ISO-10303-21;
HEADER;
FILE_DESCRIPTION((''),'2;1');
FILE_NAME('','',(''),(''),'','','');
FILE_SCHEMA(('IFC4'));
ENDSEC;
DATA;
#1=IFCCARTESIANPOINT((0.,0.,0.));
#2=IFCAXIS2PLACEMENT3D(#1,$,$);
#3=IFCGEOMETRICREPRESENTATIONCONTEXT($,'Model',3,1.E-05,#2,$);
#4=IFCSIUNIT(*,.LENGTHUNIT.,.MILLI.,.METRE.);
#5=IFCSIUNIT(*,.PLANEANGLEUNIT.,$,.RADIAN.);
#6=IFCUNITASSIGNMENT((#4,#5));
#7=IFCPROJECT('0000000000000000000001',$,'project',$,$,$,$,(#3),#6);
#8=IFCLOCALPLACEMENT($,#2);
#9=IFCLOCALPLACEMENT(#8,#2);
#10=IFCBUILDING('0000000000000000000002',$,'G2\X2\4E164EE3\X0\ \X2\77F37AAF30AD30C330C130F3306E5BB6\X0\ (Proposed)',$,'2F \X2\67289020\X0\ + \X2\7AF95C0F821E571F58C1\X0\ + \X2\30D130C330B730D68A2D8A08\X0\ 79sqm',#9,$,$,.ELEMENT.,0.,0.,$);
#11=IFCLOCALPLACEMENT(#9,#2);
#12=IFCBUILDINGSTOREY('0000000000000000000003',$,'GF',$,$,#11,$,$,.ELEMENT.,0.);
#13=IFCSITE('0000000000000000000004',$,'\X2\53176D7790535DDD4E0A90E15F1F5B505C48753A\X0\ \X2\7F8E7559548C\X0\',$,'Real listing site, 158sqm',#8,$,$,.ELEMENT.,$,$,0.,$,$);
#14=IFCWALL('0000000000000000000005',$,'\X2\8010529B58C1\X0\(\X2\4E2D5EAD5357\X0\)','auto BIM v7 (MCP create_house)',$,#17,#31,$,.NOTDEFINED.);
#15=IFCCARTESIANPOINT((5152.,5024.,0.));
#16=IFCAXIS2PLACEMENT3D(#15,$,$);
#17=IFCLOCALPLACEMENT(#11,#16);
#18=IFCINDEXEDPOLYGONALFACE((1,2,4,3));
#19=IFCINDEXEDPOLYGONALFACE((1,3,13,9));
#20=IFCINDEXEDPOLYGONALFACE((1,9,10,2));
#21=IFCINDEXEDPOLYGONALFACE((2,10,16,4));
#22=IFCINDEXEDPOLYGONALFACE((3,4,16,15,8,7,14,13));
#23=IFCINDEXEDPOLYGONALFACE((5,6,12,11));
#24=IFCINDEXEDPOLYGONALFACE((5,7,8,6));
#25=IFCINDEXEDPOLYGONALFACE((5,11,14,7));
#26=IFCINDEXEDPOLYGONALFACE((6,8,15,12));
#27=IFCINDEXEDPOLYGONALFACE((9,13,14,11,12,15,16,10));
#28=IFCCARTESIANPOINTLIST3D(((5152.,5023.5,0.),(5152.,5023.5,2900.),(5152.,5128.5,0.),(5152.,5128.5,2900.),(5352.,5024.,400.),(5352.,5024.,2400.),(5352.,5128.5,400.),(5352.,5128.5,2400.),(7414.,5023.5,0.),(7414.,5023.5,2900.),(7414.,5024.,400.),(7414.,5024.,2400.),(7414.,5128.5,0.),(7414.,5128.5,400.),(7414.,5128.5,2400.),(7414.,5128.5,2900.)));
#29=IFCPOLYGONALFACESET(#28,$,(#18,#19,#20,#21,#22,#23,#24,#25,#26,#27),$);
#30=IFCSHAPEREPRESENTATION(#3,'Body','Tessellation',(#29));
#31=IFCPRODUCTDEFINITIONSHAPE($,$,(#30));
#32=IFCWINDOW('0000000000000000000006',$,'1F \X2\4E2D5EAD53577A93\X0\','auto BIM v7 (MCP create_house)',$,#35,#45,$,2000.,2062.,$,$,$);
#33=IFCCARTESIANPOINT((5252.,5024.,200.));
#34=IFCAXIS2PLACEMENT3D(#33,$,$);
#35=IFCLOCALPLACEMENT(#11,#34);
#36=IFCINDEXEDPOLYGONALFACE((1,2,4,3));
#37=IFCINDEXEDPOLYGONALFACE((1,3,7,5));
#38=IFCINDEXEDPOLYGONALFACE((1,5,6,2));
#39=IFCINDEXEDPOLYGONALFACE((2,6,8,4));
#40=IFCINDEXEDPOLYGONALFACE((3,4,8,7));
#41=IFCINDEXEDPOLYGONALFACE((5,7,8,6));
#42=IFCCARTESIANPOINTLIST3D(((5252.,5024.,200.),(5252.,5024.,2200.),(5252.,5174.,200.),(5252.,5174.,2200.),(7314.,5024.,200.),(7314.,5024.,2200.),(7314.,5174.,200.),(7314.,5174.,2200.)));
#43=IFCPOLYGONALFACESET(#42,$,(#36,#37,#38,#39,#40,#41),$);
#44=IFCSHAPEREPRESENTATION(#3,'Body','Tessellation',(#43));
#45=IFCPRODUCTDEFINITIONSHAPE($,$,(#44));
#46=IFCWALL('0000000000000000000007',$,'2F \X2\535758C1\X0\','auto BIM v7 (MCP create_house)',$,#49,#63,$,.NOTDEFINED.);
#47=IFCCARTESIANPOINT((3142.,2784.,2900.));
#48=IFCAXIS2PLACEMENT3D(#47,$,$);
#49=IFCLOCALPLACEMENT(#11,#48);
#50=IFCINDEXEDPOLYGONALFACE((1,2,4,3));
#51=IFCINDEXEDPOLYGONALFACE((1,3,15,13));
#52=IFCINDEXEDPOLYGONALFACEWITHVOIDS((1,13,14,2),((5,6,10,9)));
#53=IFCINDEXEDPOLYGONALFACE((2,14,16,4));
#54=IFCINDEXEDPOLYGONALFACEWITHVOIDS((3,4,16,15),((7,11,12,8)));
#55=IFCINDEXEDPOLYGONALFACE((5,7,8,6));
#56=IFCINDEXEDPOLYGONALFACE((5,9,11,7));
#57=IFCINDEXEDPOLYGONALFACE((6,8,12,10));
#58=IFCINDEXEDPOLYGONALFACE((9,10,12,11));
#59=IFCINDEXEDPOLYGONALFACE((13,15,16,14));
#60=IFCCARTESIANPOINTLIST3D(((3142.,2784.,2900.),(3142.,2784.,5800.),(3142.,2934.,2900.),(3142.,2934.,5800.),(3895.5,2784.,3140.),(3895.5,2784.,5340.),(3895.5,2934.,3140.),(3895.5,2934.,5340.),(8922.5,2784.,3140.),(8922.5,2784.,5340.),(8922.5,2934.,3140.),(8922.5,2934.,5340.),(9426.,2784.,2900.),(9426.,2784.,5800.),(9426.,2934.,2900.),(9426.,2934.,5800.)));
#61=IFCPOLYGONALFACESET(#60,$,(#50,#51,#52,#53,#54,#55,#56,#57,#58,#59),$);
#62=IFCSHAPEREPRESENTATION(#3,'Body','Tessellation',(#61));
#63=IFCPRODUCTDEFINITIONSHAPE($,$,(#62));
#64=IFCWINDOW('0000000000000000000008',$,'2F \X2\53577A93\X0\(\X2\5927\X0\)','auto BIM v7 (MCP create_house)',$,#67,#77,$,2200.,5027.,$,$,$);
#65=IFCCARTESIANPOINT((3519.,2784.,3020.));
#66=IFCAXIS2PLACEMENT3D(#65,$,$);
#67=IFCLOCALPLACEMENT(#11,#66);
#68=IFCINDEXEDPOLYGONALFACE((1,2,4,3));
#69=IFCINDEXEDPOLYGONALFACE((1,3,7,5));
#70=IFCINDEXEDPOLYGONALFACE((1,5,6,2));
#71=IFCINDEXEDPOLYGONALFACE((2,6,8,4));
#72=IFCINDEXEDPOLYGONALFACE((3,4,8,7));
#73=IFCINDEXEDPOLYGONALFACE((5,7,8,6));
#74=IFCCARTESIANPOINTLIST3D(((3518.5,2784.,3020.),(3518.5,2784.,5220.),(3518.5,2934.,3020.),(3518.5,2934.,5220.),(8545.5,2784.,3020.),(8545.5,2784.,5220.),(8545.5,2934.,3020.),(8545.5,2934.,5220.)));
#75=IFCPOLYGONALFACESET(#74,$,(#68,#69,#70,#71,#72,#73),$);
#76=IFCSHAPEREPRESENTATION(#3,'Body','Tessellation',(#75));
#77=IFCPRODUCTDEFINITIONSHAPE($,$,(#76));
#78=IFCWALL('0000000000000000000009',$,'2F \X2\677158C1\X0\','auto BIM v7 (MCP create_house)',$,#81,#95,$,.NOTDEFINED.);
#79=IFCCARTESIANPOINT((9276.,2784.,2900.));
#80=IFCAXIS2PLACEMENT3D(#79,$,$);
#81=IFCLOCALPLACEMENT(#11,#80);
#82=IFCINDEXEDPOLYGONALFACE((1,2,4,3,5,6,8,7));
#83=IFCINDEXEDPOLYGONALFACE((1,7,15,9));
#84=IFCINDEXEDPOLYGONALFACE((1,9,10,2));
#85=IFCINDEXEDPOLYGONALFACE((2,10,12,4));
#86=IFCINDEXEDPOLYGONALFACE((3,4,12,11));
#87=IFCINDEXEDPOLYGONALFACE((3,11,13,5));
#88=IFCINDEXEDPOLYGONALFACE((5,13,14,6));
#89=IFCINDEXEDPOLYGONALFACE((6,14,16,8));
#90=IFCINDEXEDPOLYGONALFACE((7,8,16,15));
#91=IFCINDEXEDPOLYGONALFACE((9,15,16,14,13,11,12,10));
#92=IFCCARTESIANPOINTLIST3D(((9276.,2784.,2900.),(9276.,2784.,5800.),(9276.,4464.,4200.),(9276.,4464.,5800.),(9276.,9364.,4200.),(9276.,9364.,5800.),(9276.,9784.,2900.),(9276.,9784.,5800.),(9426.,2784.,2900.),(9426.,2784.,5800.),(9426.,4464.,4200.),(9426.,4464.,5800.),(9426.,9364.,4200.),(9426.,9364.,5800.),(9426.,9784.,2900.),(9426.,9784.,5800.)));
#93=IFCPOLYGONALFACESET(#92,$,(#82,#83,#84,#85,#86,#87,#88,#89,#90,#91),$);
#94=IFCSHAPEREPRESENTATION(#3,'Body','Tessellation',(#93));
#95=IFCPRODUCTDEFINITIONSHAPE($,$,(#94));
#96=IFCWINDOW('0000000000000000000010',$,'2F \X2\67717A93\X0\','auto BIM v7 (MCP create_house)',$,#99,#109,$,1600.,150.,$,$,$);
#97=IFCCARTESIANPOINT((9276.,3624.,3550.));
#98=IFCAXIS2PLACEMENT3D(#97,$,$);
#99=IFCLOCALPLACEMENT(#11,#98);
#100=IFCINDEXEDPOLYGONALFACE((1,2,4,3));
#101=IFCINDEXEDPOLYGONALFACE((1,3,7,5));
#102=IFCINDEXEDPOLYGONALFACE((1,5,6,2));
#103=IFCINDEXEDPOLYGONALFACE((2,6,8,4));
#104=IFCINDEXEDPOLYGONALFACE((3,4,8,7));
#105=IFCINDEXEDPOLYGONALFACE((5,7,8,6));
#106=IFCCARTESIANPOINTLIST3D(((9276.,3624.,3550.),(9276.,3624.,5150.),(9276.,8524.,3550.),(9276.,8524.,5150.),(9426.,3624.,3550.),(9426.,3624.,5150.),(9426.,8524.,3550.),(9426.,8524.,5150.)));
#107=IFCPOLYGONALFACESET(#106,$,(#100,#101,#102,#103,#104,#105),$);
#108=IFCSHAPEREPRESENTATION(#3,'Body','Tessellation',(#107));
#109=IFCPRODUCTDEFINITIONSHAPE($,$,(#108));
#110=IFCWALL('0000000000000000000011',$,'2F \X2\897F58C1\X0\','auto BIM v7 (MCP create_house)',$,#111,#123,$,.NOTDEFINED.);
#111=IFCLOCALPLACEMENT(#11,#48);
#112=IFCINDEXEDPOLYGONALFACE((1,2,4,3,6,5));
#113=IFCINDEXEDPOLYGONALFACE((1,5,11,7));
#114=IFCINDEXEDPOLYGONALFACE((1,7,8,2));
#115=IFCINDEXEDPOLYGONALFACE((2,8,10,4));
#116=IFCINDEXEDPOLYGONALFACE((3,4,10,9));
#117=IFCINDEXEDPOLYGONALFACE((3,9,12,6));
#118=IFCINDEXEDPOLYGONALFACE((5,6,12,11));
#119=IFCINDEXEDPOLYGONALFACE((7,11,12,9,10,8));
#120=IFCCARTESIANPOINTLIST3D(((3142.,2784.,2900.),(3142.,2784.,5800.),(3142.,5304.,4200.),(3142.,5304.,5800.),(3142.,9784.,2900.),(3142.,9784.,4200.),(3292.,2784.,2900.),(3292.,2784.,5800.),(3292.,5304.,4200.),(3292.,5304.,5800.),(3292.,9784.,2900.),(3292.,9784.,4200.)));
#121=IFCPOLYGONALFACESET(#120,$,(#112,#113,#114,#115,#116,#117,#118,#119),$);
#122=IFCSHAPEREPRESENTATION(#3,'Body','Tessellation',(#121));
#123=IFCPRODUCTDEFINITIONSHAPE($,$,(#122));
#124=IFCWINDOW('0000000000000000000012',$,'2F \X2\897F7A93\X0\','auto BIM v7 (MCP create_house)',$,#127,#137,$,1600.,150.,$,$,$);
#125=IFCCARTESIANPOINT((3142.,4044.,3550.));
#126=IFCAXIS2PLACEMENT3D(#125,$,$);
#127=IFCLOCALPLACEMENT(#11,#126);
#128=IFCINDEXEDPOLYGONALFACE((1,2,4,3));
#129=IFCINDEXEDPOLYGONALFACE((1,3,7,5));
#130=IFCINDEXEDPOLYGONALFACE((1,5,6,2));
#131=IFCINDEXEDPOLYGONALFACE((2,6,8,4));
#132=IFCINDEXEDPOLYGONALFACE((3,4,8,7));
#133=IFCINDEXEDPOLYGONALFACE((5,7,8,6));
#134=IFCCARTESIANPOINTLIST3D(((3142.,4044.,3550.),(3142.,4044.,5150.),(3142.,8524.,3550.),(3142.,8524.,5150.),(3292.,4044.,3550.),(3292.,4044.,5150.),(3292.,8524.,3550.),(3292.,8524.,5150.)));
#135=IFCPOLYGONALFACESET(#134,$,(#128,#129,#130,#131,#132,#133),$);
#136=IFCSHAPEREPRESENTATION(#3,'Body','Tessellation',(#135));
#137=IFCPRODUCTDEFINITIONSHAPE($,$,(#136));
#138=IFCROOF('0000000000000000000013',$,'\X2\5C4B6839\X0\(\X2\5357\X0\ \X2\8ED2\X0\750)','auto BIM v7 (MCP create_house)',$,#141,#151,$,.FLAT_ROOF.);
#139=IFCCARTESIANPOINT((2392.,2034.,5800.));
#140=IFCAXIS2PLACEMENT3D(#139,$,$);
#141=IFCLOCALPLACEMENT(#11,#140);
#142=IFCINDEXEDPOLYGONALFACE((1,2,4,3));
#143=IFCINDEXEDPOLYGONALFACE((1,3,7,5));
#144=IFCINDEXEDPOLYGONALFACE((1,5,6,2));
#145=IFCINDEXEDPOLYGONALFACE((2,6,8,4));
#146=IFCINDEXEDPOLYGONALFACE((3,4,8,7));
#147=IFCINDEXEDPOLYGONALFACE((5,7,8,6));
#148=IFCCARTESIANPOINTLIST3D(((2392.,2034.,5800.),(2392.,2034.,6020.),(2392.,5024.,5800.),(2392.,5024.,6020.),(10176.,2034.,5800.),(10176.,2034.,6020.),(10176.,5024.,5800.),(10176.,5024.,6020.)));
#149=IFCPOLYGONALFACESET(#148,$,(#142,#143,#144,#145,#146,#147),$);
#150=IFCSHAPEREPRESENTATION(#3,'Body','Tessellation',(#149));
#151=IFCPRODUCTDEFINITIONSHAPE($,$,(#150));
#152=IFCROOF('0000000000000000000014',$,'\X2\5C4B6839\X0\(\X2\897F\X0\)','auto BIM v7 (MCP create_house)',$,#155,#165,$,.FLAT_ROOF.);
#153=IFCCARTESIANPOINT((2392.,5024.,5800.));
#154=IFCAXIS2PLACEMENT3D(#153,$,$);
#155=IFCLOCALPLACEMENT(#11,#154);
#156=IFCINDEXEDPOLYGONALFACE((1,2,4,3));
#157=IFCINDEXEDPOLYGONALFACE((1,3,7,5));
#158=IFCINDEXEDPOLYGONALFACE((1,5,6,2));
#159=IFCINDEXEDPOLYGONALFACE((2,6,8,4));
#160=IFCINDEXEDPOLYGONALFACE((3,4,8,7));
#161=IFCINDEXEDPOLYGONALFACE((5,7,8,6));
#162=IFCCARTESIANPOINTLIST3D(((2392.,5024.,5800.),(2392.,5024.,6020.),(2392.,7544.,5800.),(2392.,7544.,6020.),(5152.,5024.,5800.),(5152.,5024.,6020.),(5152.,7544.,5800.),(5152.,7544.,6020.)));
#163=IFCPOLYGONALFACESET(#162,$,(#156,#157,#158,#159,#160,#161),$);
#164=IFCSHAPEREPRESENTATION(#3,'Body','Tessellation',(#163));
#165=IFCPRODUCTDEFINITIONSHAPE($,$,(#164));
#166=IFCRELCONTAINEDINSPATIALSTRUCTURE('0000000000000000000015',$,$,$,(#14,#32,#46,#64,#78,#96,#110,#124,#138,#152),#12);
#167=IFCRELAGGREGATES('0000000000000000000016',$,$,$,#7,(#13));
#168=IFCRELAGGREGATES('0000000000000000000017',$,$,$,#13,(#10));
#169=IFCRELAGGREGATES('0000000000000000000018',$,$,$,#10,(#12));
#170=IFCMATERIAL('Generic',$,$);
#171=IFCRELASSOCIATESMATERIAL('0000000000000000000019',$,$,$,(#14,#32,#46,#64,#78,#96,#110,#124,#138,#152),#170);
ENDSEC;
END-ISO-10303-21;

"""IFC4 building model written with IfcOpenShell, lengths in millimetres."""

from ifc_helpers import new_model, si_unit, frame, frame_2d, origin, place, context, project, spatial, rectangle, extrude, material, element, fill, save


model = new_model("IFC4")

# Units and contexts
model_context = context("Model", 3, precision=1e-05, world=origin())
ifc_project = project(units=[si_unit("LENGTHUNIT", "METRE", prefix="MILLI"), si_unit("PLANEANGLEUNIT", "RADIAN")], contexts=[model_context])

# Site, building, storey
site_placement = place(None, origin())
site = spatial("IfcSite", under=ifc_project, at=site_placement, Name="北海道川上郡弟子屈町 美留和", ObjectType="Real listing site, 158sqm", CompositionType="ELEMENT", RefElevation=0.0)
building_placement = place(site_placement, origin())
building = spatial("IfcBuilding", under=site, at=building_placement, Name="G2世代 石窯キッチンの家 (Proposed)", ObjectType="2F 木造 + 竹小舞土壁 + パッシブ設計 79sqm", CompositionType="ELEMENT", ElevationOfRefHeight=0.0, ElevationOfTerrain=0.0)
storey_placement = place(building_placement, origin())
storey = spatial("IfcBuildingStorey", under=building, at=storey_placement, Name="GF", CompositionType="ELEMENT", Elevation=0.0)

# Shared definitions
ifc_material = material(Name="Generic")

# Wall, opening, window
wall_1_placement = place(storey_placement, frame((5152.0, 5024.0, 0.0)))
wall_1 = element("IfcWall", 1, at=wall_1_placement, inside=storey, material=ifc_material, Name="耐力壁(中庭南)", Description="auto BIM v7 (MCP create_house)", PredefinedType="NOTDEFINED", context=model_context, shape_type="SweptSolid", body=[
    extrude(rectangle(XDim=2262.0, YDim=105.0, at=frame_2d((1131.0, 52.0))), frame((5152.0, 5024.0, 0.0)), (0.0, 0.0, 1.0), 2900.0),
])
opening_1_placement = place(storey_placement, frame((5252.0, 5024.0, 200.0)))
opening_1 = element("IfcOpeningElement", 2, at=opening_1_placement, cuts=wall_1, PredefinedType="NOTDEFINED", context=model_context, shape_type="SweptSolid", body=[
    extrude(rectangle(XDim=2062.0, YDim=150.0, at=frame_2d((1031.0, 75.0))), frame((5252.0, 5024.0, 200.0)), (0.0, 0.0, 1.0), 2000.0),
])
window_1_placement = place(storey_placement, frame((5252.0, 5024.0, 200.0)))
window_1 = element("IfcWindow", 3, at=window_1_placement, inside=storey, material=ifc_material, Name="1F 中庭南窓", Description="auto BIM v7 (MCP create_house)", OverallHeight=2000.0, OverallWidth=2062.0, context=model_context, shape_type="SweptSolid", body=[
    extrude(rectangle(XDim=2062.0, YDim=150.0, at=frame_2d((1031.0, 75.0))), frame((5252.0, 5024.0, 200.0)), (0.0, 0.0, 1.0), 2000.0),
])
fill(opening_1, window_1)

# Walls, openings, windows
wall_2_placement = place(storey_placement, frame((3142.0, 2784.0, 2900.0)))
wall_2 = element("IfcWall", 4, at=wall_2_placement, inside=storey, material=ifc_material, Name="2F 南壁", Description="auto BIM v7 (MCP create_house)", PredefinedType="NOTDEFINED", context=model_context, shape_type="SweptSolid", body=[
    extrude(rectangle(XDim=6284.0, YDim=150.0, at=frame_2d((3142.0, 75.0))), frame((3142.0, 2784.0, 2900.0)), (0.0, 0.0, 1.0), 2900.0),
])
opening_2_placement = place(storey_placement, frame((3519.0, 2784.0, 3020.0)))
opening_2 = element("IfcOpeningElement", 5, at=opening_2_placement, cuts=wall_2, PredefinedType="NOTDEFINED", context=model_context, shape_type="SweptSolid", body=[
    extrude(rectangle(XDim=5027.0, YDim=150.0, at=frame_2d((2513.0, 75.0))), frame((3519.0, 2784.0, 3020.0)), (0.0, 0.0, 1.0), 2200.0),
])
window_2_placement = place(storey_placement, frame((3519.0, 2784.0, 3020.0)))
window_2 = element("IfcWindow", 6, at=window_2_placement, inside=storey, material=ifc_material, Name="2F 南窓(大)", Description="auto BIM v7 (MCP create_house)", OverallHeight=2200.0, OverallWidth=5027.0, context=model_context, shape_type="SweptSolid", body=[
    extrude(rectangle(XDim=5027.0, YDim=150.0, at=frame_2d((2513.0, 75.0))), frame((3519.0, 2784.0, 3020.0)), (0.0, 0.0, 1.0), 2200.0),
])
fill(opening_2, window_2)
wall_3_placement = place(storey_placement, frame((9276.0, 2784.0, 2900.0)))
wall_3 = element("IfcWall", 7, at=wall_3_placement, inside=storey, material=ifc_material, Name="2F 東壁", Description="auto BIM v7 (MCP create_house)", PredefinedType="NOTDEFINED", context=model_context, shape_type="SweptSolid", body=[
    extrude(rectangle(XDim=150.0, YDim=7000.0, at=frame_2d((75.0, 3500.0))), frame((9276.0, 2784.0, 2900.0)), (0.0, 0.0, 1.0), 2900.0),
])
opening_3_placement = place(storey_placement, frame((9276.0, 3624.0, 3550.0)))
opening_3 = element("IfcOpeningElement", 8, at=opening_3_placement, cuts=wall_3, PredefinedType="NOTDEFINED", context=model_context, shape_type="SweptSolid", body=[
    extrude(rectangle(XDim=150.0, YDim=4900.0, at=frame_2d((75.0, 2450.0))), frame((9276.0, 3624.0, 3550.0)), (0.0, 0.0, 1.0), 1600.0),
])
window_3_placement = place(storey_placement, frame((9276.0, 3624.0, 3550.0)))
window_3 = element("IfcWindow", 9, at=window_3_placement, inside=storey, material=ifc_material, Name="2F 東窓", Description="auto BIM v7 (MCP create_house)", OverallHeight=1600.0, OverallWidth=150.0, context=model_context, shape_type="SweptSolid", body=[
    extrude(rectangle(XDim=150.0, YDim=4900.0, at=frame_2d((75.0, 2450.0))), frame((9276.0, 3624.0, 3550.0)), (0.0, 0.0, 1.0), 1600.0),
])
fill(opening_3, window_3)
wall_4_placement = place(storey_placement, frame((3142.0, 2784.0, 2900.0)))
wall_4 = element("IfcWall", 10, at=wall_4_placement, inside=storey, material=ifc_material, Name="2F 西壁", Description="auto BIM v7 (MCP create_house)", PredefinedType="NOTDEFINED", context=model_context, shape_type="SweptSolid", body=[
    extrude(rectangle(XDim=150.0, YDim=7000.0, at=frame_2d((75.0, 3500.0))), frame((3142.0, 2784.0, 2900.0)), (0.0, 0.0, 1.0), 2900.0),
])
opening_4_placement = place(storey_placement, frame((3142.0, 4044.0, 3550.0)))
opening_4 = element("IfcOpeningElement", 11, at=opening_4_placement, cuts=wall_4, PredefinedType="NOTDEFINED", context=model_context, shape_type="SweptSolid", body=[
    extrude(rectangle(XDim=150.0, YDim=4480.0, at=frame_2d((75.0, 2240.0))), frame((3142.0, 4044.0, 3550.0)), (0.0, 0.0, 1.0), 1600.0),
])
window_4_placement = place(storey_placement, frame((3142.0, 4044.0, 3550.0)))
window_4 = element("IfcWindow", 12, at=window_4_placement, inside=storey, material=ifc_material, Name="2F 西窓", Description="auto BIM v7 (MCP create_house)", OverallHeight=1600.0, OverallWidth=150.0, context=model_context, shape_type="SweptSolid", body=[
    extrude(rectangle(XDim=150.0, YDim=4480.0, at=frame_2d((75.0, 2240.0))), frame((3142.0, 4044.0, 3550.0)), (0.0, 0.0, 1.0), 1600.0),
])
fill(opening_4, window_4)

# Roofs
roof_1_placement = place(storey_placement, frame((2392.0, 2034.0, 5800.0)))
element("IfcRoof", 13, at=roof_1_placement, inside=storey, material=ifc_material, Name="屋根(南 軒750)", Description="auto BIM v7 (MCP create_house)", PredefinedType="FLAT_ROOF", context=model_context, shape_type="SweptSolid", body=[
    extrude(rectangle(XDim=7784.0, YDim=2990.0, at=frame_2d((3892.0, 1495.0))), frame((2392.0, 2034.0, 5800.0)), (0.0, 0.0, 1.0), 220.0),
])
roof_2_placement = place(storey_placement, frame((2392.0, 5024.0, 5800.0)))
element("IfcRoof", 14, at=roof_2_placement, inside=storey, material=ifc_material, Name="屋根(西)", Description="auto BIM v7 (MCP create_house)", PredefinedType="FLAT_ROOF", context=model_context, shape_type="SweptSolid", body=[
    extrude(rectangle(XDim=2760.0, YDim=2520.0, at=frame_2d((1380.0, 1260.0))), frame((2392.0, 5024.0, 5800.0)), (0.0, 0.0, 1.0), 220.0),
])

save(model, "model.ifc")
